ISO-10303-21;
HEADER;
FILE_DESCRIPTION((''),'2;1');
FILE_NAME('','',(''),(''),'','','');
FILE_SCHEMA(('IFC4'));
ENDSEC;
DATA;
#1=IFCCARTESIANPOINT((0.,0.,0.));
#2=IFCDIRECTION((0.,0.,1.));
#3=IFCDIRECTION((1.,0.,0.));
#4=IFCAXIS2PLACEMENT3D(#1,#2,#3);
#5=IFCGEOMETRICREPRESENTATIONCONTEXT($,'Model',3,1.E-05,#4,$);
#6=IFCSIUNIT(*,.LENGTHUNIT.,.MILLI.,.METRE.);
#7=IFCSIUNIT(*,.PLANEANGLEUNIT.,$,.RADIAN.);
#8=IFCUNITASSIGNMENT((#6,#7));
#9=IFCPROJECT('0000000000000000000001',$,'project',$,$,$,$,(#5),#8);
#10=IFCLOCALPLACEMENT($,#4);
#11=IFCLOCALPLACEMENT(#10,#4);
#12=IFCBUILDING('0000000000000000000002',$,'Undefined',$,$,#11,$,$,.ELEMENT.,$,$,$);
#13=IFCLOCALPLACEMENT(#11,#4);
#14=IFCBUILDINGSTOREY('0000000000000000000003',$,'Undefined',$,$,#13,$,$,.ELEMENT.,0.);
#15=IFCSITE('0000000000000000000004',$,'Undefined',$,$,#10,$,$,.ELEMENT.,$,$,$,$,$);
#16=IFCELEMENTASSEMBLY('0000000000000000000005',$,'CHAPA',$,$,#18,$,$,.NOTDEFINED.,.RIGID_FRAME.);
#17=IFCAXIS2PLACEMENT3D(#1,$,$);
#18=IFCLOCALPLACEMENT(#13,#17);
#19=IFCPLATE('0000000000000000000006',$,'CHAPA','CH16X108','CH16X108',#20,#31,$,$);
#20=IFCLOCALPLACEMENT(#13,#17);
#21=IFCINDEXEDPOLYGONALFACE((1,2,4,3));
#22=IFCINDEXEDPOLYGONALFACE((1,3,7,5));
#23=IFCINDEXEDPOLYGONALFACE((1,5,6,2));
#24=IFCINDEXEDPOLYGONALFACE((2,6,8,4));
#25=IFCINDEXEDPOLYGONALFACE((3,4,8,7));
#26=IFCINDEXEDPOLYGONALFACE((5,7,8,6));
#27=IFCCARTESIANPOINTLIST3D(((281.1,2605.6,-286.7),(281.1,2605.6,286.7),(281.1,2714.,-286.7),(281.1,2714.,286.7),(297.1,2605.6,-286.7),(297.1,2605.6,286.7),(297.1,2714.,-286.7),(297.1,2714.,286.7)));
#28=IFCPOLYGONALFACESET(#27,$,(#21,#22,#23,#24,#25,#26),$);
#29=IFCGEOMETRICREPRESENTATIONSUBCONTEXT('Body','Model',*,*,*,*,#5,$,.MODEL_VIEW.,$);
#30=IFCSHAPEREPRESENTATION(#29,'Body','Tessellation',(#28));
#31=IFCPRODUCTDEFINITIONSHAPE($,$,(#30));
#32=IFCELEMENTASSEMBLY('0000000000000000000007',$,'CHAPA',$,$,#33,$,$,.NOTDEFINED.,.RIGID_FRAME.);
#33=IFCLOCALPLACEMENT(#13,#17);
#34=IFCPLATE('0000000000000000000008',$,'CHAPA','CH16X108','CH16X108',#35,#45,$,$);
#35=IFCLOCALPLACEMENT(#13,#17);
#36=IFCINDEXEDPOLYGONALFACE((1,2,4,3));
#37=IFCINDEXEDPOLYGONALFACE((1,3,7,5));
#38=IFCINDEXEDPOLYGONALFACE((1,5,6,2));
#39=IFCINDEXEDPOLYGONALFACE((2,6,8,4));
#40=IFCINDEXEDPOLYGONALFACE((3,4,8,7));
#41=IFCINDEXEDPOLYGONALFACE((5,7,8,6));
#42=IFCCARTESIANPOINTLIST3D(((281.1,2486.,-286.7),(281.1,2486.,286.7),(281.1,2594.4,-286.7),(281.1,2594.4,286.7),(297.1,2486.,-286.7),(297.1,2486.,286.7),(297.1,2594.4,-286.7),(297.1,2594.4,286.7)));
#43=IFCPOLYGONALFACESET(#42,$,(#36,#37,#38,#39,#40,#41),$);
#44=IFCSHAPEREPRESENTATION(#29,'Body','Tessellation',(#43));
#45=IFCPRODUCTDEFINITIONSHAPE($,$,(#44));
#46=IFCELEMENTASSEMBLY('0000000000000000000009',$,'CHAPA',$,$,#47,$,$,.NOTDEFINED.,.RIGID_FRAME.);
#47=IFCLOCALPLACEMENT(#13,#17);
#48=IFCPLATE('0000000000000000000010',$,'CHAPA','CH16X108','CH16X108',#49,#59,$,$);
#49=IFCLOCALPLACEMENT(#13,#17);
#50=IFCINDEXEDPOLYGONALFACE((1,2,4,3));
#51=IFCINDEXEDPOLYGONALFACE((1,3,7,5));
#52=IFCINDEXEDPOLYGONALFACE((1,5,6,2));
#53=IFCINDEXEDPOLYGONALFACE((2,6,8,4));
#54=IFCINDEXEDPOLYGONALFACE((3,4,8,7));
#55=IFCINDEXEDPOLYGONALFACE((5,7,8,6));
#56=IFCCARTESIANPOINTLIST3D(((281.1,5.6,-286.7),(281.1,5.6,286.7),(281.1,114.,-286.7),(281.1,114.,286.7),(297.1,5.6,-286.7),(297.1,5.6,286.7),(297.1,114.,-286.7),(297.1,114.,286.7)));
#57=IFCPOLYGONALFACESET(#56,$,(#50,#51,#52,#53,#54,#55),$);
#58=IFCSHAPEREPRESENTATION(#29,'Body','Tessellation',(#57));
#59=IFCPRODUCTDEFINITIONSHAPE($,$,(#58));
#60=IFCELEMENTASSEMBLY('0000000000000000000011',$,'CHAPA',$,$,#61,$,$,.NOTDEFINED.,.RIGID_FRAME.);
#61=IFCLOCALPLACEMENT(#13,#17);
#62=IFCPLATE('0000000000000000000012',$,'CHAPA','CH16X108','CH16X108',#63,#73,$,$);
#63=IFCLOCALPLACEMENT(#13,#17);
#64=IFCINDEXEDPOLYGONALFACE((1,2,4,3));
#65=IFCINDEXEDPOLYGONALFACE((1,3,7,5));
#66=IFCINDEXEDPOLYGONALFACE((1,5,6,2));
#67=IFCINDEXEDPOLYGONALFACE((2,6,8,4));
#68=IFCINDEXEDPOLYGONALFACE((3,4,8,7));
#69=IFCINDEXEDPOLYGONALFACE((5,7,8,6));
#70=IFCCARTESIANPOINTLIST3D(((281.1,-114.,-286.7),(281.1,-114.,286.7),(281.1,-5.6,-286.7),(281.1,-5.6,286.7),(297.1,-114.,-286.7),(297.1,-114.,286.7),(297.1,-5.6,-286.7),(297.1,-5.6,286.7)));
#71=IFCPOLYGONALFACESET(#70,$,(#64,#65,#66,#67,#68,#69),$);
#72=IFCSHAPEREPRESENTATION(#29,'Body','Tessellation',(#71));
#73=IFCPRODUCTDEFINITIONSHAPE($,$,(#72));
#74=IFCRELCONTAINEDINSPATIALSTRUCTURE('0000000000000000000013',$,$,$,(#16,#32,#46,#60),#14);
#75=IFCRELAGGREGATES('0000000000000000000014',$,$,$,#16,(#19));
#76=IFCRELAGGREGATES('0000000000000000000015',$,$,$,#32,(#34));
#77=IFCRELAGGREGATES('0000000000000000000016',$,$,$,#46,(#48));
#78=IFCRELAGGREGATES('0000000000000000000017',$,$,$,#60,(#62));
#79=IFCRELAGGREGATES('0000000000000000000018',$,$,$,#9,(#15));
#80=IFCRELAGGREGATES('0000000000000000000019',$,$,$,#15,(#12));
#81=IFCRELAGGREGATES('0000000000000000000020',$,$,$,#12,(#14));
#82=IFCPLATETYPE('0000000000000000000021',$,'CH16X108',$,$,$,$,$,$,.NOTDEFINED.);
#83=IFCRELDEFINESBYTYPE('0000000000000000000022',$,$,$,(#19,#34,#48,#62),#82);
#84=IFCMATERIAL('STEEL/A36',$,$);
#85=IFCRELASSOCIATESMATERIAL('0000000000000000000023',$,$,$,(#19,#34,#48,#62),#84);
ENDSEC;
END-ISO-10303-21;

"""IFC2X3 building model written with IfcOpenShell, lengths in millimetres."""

from ifc_helpers import new_model, si_unit, frame, origin_with_axes, place, context, subcontext, project, spatial, polyline, outline, extrude, material, type_object, element, aggregate, save


model = new_model("IFC2X3")

# Units and contexts
model_context = context("Model", 3, precision=1e-05, world=origin_with_axes())
body_context = subcontext(model_context, "Body", "Model", "MODEL_VIEW")
ifc_project = project(units=[si_unit("LENGTHUNIT", "METRE", prefix="MILLI"), si_unit("PLANEANGLEUNIT", "RADIAN")], contexts=[model_context])

# Site, building, storey
site_placement = place(None, origin_with_axes())
site = spatial("IfcSite", under=ifc_project, at=site_placement, Name="Undefined", CompositionType="ELEMENT")
building_placement = place(site_placement, origin_with_axes())
building = spatial("IfcBuilding", under=site, at=building_placement, Name="Undefined", CompositionType="ELEMENT")
storey_placement = place(building_placement, origin_with_axes())
storey = spatial("IfcBuildingStorey", under=building, at=storey_placement, Name="Undefined", CompositionType="ELEMENT", Elevation=0.0)

# Element assemblies, plates
assembly_1_placement = place(storey_placement, origin_with_axes())
assembly_1 = element("IfcElementAssembly", 1, at=assembly_1_placement, inside=storey, Name="CHAPA", AssemblyPlace="NOTDEFINED", PredefinedType="RIGID_FRAME")
ifc_material_1 = material(Name="STEEL/A36")
plate_type = type_object("IfcPlateType", Name="CH16X108", PredefinedType="NOTDEFINED")
plate_1_placement = place(assembly_1_placement, frame((289.1, 2605.6, 286.7), z_axis=(-1.0, 0.0, 0.0), x_axis=(0.0, 1.0, 0.0)))
plate_1 = element("IfcPlate", 2, at=plate_1_placement, type_object=plate_type, material=ifc_material_1, Name="CHAPA", Description="CH16X108", ObjectType="CH16X108", context=body_context, shape_type="SweptSolid", body=[
    extrude(outline(polyline([(0.0, 0.0), (108.4, 0.0), (108.4, 573.4), (0.0, 573.4), (0.0, 0.0)])), frame((0.0, 0.0, -8.0), z_axis=(0.0, 0.0, 1.0), x_axis=(1.0, 0.0, 0.0)), (0.0, 0.0, 1.0), 16.0),
])
aggregate(assembly_1, [plate_1])
assembly_2_placement = place(storey_placement, origin_with_axes())
assembly_2 = element("IfcElementAssembly", 3, at=assembly_2_placement, inside=storey, Name="CHAPA", AssemblyPlace="NOTDEFINED", PredefinedType="RIGID_FRAME")
plate_2_placement = place(assembly_2_placement, frame((289.1, 2486.0, 286.7), z_axis=(-1.0, 0.0, 0.0), x_axis=(0.0, 1.0, 0.0)))
plate_2 = element("IfcPlate", 4, at=plate_2_placement, type_object=plate_type, material=ifc_material_1, Name="CHAPA", Description="CH16X108", ObjectType="CH16X108", context=body_context, shape_type="SweptSolid", body=[
    extrude(outline(polyline([(0.0, 0.0), (108.4, 0.0), (108.4, 573.4), (0.0, 573.4), (0.0, 0.0)])), frame((0.0, 0.0, -8.0), z_axis=(0.0, 0.0, 1.0), x_axis=(1.0, 0.0, 0.0)), (0.0, 0.0, 1.0), 16.0),
])
aggregate(assembly_2, [plate_2])
assembly_3_placement = place(storey_placement, origin_with_axes())
assembly_3 = element("IfcElementAssembly", 5, at=assembly_3_placement, inside=storey, Name="CHAPA", AssemblyPlace="NOTDEFINED", PredefinedType="RIGID_FRAME")
plate_3_placement = place(assembly_3_placement, frame((289.1, 5.6, 286.7), z_axis=(-1.0, 0.0, 0.0), x_axis=(0.0, 1.0, 0.0)))
plate_3 = element("IfcPlate", 6, at=plate_3_placement, type_object=plate_type, material=ifc_material_1, Name="CHAPA", Description="CH16X108", ObjectType="CH16X108", context=body_context, shape_type="SweptSolid", body=[
    extrude(outline(polyline([(0.0, 0.0), (108.4, 0.0), (108.4, 573.4), (0.0, 573.4), (0.0, 0.0)])), frame((0.0, 0.0, -8.0), z_axis=(0.0, 0.0, 1.0), x_axis=(1.0, 0.0, 0.0)), (0.0, 0.0, 1.0), 16.0),
])
aggregate(assembly_3, [plate_3])
assembly_4_placement = place(storey_placement, origin_with_axes())
assembly_4 = element("IfcElementAssembly", 7, at=assembly_4_placement, inside=storey, Name="CHAPA", AssemblyPlace="NOTDEFINED", PredefinedType="RIGID_FRAME")
plate_4_placement = place(assembly_4_placement, frame((289.1, -114.0, 286.7), z_axis=(-1.0, 0.0, 0.0), x_axis=(0.0, 1.0, 0.0)))
plate_4 = element("IfcPlate", 8, at=plate_4_placement, type_object=plate_type, material=ifc_material_1, Name="CHAPA", Description="CH16X108", ObjectType="CH16X108", context=body_context, shape_type="SweptSolid", body=[
    extrude(outline(polyline([(0.0, 0.0), (108.4, 0.0), (108.4, 573.4), (0.0, 573.4), (0.0, 0.0)])), frame((0.0, 0.0, -8.0), z_axis=(0.0, 0.0, 1.0), x_axis=(1.0, 0.0, 0.0)), (0.0, 0.0, 1.0), 16.0),
])
aggregate(assembly_4, [plate_4])

save(model, "model.ifc")
